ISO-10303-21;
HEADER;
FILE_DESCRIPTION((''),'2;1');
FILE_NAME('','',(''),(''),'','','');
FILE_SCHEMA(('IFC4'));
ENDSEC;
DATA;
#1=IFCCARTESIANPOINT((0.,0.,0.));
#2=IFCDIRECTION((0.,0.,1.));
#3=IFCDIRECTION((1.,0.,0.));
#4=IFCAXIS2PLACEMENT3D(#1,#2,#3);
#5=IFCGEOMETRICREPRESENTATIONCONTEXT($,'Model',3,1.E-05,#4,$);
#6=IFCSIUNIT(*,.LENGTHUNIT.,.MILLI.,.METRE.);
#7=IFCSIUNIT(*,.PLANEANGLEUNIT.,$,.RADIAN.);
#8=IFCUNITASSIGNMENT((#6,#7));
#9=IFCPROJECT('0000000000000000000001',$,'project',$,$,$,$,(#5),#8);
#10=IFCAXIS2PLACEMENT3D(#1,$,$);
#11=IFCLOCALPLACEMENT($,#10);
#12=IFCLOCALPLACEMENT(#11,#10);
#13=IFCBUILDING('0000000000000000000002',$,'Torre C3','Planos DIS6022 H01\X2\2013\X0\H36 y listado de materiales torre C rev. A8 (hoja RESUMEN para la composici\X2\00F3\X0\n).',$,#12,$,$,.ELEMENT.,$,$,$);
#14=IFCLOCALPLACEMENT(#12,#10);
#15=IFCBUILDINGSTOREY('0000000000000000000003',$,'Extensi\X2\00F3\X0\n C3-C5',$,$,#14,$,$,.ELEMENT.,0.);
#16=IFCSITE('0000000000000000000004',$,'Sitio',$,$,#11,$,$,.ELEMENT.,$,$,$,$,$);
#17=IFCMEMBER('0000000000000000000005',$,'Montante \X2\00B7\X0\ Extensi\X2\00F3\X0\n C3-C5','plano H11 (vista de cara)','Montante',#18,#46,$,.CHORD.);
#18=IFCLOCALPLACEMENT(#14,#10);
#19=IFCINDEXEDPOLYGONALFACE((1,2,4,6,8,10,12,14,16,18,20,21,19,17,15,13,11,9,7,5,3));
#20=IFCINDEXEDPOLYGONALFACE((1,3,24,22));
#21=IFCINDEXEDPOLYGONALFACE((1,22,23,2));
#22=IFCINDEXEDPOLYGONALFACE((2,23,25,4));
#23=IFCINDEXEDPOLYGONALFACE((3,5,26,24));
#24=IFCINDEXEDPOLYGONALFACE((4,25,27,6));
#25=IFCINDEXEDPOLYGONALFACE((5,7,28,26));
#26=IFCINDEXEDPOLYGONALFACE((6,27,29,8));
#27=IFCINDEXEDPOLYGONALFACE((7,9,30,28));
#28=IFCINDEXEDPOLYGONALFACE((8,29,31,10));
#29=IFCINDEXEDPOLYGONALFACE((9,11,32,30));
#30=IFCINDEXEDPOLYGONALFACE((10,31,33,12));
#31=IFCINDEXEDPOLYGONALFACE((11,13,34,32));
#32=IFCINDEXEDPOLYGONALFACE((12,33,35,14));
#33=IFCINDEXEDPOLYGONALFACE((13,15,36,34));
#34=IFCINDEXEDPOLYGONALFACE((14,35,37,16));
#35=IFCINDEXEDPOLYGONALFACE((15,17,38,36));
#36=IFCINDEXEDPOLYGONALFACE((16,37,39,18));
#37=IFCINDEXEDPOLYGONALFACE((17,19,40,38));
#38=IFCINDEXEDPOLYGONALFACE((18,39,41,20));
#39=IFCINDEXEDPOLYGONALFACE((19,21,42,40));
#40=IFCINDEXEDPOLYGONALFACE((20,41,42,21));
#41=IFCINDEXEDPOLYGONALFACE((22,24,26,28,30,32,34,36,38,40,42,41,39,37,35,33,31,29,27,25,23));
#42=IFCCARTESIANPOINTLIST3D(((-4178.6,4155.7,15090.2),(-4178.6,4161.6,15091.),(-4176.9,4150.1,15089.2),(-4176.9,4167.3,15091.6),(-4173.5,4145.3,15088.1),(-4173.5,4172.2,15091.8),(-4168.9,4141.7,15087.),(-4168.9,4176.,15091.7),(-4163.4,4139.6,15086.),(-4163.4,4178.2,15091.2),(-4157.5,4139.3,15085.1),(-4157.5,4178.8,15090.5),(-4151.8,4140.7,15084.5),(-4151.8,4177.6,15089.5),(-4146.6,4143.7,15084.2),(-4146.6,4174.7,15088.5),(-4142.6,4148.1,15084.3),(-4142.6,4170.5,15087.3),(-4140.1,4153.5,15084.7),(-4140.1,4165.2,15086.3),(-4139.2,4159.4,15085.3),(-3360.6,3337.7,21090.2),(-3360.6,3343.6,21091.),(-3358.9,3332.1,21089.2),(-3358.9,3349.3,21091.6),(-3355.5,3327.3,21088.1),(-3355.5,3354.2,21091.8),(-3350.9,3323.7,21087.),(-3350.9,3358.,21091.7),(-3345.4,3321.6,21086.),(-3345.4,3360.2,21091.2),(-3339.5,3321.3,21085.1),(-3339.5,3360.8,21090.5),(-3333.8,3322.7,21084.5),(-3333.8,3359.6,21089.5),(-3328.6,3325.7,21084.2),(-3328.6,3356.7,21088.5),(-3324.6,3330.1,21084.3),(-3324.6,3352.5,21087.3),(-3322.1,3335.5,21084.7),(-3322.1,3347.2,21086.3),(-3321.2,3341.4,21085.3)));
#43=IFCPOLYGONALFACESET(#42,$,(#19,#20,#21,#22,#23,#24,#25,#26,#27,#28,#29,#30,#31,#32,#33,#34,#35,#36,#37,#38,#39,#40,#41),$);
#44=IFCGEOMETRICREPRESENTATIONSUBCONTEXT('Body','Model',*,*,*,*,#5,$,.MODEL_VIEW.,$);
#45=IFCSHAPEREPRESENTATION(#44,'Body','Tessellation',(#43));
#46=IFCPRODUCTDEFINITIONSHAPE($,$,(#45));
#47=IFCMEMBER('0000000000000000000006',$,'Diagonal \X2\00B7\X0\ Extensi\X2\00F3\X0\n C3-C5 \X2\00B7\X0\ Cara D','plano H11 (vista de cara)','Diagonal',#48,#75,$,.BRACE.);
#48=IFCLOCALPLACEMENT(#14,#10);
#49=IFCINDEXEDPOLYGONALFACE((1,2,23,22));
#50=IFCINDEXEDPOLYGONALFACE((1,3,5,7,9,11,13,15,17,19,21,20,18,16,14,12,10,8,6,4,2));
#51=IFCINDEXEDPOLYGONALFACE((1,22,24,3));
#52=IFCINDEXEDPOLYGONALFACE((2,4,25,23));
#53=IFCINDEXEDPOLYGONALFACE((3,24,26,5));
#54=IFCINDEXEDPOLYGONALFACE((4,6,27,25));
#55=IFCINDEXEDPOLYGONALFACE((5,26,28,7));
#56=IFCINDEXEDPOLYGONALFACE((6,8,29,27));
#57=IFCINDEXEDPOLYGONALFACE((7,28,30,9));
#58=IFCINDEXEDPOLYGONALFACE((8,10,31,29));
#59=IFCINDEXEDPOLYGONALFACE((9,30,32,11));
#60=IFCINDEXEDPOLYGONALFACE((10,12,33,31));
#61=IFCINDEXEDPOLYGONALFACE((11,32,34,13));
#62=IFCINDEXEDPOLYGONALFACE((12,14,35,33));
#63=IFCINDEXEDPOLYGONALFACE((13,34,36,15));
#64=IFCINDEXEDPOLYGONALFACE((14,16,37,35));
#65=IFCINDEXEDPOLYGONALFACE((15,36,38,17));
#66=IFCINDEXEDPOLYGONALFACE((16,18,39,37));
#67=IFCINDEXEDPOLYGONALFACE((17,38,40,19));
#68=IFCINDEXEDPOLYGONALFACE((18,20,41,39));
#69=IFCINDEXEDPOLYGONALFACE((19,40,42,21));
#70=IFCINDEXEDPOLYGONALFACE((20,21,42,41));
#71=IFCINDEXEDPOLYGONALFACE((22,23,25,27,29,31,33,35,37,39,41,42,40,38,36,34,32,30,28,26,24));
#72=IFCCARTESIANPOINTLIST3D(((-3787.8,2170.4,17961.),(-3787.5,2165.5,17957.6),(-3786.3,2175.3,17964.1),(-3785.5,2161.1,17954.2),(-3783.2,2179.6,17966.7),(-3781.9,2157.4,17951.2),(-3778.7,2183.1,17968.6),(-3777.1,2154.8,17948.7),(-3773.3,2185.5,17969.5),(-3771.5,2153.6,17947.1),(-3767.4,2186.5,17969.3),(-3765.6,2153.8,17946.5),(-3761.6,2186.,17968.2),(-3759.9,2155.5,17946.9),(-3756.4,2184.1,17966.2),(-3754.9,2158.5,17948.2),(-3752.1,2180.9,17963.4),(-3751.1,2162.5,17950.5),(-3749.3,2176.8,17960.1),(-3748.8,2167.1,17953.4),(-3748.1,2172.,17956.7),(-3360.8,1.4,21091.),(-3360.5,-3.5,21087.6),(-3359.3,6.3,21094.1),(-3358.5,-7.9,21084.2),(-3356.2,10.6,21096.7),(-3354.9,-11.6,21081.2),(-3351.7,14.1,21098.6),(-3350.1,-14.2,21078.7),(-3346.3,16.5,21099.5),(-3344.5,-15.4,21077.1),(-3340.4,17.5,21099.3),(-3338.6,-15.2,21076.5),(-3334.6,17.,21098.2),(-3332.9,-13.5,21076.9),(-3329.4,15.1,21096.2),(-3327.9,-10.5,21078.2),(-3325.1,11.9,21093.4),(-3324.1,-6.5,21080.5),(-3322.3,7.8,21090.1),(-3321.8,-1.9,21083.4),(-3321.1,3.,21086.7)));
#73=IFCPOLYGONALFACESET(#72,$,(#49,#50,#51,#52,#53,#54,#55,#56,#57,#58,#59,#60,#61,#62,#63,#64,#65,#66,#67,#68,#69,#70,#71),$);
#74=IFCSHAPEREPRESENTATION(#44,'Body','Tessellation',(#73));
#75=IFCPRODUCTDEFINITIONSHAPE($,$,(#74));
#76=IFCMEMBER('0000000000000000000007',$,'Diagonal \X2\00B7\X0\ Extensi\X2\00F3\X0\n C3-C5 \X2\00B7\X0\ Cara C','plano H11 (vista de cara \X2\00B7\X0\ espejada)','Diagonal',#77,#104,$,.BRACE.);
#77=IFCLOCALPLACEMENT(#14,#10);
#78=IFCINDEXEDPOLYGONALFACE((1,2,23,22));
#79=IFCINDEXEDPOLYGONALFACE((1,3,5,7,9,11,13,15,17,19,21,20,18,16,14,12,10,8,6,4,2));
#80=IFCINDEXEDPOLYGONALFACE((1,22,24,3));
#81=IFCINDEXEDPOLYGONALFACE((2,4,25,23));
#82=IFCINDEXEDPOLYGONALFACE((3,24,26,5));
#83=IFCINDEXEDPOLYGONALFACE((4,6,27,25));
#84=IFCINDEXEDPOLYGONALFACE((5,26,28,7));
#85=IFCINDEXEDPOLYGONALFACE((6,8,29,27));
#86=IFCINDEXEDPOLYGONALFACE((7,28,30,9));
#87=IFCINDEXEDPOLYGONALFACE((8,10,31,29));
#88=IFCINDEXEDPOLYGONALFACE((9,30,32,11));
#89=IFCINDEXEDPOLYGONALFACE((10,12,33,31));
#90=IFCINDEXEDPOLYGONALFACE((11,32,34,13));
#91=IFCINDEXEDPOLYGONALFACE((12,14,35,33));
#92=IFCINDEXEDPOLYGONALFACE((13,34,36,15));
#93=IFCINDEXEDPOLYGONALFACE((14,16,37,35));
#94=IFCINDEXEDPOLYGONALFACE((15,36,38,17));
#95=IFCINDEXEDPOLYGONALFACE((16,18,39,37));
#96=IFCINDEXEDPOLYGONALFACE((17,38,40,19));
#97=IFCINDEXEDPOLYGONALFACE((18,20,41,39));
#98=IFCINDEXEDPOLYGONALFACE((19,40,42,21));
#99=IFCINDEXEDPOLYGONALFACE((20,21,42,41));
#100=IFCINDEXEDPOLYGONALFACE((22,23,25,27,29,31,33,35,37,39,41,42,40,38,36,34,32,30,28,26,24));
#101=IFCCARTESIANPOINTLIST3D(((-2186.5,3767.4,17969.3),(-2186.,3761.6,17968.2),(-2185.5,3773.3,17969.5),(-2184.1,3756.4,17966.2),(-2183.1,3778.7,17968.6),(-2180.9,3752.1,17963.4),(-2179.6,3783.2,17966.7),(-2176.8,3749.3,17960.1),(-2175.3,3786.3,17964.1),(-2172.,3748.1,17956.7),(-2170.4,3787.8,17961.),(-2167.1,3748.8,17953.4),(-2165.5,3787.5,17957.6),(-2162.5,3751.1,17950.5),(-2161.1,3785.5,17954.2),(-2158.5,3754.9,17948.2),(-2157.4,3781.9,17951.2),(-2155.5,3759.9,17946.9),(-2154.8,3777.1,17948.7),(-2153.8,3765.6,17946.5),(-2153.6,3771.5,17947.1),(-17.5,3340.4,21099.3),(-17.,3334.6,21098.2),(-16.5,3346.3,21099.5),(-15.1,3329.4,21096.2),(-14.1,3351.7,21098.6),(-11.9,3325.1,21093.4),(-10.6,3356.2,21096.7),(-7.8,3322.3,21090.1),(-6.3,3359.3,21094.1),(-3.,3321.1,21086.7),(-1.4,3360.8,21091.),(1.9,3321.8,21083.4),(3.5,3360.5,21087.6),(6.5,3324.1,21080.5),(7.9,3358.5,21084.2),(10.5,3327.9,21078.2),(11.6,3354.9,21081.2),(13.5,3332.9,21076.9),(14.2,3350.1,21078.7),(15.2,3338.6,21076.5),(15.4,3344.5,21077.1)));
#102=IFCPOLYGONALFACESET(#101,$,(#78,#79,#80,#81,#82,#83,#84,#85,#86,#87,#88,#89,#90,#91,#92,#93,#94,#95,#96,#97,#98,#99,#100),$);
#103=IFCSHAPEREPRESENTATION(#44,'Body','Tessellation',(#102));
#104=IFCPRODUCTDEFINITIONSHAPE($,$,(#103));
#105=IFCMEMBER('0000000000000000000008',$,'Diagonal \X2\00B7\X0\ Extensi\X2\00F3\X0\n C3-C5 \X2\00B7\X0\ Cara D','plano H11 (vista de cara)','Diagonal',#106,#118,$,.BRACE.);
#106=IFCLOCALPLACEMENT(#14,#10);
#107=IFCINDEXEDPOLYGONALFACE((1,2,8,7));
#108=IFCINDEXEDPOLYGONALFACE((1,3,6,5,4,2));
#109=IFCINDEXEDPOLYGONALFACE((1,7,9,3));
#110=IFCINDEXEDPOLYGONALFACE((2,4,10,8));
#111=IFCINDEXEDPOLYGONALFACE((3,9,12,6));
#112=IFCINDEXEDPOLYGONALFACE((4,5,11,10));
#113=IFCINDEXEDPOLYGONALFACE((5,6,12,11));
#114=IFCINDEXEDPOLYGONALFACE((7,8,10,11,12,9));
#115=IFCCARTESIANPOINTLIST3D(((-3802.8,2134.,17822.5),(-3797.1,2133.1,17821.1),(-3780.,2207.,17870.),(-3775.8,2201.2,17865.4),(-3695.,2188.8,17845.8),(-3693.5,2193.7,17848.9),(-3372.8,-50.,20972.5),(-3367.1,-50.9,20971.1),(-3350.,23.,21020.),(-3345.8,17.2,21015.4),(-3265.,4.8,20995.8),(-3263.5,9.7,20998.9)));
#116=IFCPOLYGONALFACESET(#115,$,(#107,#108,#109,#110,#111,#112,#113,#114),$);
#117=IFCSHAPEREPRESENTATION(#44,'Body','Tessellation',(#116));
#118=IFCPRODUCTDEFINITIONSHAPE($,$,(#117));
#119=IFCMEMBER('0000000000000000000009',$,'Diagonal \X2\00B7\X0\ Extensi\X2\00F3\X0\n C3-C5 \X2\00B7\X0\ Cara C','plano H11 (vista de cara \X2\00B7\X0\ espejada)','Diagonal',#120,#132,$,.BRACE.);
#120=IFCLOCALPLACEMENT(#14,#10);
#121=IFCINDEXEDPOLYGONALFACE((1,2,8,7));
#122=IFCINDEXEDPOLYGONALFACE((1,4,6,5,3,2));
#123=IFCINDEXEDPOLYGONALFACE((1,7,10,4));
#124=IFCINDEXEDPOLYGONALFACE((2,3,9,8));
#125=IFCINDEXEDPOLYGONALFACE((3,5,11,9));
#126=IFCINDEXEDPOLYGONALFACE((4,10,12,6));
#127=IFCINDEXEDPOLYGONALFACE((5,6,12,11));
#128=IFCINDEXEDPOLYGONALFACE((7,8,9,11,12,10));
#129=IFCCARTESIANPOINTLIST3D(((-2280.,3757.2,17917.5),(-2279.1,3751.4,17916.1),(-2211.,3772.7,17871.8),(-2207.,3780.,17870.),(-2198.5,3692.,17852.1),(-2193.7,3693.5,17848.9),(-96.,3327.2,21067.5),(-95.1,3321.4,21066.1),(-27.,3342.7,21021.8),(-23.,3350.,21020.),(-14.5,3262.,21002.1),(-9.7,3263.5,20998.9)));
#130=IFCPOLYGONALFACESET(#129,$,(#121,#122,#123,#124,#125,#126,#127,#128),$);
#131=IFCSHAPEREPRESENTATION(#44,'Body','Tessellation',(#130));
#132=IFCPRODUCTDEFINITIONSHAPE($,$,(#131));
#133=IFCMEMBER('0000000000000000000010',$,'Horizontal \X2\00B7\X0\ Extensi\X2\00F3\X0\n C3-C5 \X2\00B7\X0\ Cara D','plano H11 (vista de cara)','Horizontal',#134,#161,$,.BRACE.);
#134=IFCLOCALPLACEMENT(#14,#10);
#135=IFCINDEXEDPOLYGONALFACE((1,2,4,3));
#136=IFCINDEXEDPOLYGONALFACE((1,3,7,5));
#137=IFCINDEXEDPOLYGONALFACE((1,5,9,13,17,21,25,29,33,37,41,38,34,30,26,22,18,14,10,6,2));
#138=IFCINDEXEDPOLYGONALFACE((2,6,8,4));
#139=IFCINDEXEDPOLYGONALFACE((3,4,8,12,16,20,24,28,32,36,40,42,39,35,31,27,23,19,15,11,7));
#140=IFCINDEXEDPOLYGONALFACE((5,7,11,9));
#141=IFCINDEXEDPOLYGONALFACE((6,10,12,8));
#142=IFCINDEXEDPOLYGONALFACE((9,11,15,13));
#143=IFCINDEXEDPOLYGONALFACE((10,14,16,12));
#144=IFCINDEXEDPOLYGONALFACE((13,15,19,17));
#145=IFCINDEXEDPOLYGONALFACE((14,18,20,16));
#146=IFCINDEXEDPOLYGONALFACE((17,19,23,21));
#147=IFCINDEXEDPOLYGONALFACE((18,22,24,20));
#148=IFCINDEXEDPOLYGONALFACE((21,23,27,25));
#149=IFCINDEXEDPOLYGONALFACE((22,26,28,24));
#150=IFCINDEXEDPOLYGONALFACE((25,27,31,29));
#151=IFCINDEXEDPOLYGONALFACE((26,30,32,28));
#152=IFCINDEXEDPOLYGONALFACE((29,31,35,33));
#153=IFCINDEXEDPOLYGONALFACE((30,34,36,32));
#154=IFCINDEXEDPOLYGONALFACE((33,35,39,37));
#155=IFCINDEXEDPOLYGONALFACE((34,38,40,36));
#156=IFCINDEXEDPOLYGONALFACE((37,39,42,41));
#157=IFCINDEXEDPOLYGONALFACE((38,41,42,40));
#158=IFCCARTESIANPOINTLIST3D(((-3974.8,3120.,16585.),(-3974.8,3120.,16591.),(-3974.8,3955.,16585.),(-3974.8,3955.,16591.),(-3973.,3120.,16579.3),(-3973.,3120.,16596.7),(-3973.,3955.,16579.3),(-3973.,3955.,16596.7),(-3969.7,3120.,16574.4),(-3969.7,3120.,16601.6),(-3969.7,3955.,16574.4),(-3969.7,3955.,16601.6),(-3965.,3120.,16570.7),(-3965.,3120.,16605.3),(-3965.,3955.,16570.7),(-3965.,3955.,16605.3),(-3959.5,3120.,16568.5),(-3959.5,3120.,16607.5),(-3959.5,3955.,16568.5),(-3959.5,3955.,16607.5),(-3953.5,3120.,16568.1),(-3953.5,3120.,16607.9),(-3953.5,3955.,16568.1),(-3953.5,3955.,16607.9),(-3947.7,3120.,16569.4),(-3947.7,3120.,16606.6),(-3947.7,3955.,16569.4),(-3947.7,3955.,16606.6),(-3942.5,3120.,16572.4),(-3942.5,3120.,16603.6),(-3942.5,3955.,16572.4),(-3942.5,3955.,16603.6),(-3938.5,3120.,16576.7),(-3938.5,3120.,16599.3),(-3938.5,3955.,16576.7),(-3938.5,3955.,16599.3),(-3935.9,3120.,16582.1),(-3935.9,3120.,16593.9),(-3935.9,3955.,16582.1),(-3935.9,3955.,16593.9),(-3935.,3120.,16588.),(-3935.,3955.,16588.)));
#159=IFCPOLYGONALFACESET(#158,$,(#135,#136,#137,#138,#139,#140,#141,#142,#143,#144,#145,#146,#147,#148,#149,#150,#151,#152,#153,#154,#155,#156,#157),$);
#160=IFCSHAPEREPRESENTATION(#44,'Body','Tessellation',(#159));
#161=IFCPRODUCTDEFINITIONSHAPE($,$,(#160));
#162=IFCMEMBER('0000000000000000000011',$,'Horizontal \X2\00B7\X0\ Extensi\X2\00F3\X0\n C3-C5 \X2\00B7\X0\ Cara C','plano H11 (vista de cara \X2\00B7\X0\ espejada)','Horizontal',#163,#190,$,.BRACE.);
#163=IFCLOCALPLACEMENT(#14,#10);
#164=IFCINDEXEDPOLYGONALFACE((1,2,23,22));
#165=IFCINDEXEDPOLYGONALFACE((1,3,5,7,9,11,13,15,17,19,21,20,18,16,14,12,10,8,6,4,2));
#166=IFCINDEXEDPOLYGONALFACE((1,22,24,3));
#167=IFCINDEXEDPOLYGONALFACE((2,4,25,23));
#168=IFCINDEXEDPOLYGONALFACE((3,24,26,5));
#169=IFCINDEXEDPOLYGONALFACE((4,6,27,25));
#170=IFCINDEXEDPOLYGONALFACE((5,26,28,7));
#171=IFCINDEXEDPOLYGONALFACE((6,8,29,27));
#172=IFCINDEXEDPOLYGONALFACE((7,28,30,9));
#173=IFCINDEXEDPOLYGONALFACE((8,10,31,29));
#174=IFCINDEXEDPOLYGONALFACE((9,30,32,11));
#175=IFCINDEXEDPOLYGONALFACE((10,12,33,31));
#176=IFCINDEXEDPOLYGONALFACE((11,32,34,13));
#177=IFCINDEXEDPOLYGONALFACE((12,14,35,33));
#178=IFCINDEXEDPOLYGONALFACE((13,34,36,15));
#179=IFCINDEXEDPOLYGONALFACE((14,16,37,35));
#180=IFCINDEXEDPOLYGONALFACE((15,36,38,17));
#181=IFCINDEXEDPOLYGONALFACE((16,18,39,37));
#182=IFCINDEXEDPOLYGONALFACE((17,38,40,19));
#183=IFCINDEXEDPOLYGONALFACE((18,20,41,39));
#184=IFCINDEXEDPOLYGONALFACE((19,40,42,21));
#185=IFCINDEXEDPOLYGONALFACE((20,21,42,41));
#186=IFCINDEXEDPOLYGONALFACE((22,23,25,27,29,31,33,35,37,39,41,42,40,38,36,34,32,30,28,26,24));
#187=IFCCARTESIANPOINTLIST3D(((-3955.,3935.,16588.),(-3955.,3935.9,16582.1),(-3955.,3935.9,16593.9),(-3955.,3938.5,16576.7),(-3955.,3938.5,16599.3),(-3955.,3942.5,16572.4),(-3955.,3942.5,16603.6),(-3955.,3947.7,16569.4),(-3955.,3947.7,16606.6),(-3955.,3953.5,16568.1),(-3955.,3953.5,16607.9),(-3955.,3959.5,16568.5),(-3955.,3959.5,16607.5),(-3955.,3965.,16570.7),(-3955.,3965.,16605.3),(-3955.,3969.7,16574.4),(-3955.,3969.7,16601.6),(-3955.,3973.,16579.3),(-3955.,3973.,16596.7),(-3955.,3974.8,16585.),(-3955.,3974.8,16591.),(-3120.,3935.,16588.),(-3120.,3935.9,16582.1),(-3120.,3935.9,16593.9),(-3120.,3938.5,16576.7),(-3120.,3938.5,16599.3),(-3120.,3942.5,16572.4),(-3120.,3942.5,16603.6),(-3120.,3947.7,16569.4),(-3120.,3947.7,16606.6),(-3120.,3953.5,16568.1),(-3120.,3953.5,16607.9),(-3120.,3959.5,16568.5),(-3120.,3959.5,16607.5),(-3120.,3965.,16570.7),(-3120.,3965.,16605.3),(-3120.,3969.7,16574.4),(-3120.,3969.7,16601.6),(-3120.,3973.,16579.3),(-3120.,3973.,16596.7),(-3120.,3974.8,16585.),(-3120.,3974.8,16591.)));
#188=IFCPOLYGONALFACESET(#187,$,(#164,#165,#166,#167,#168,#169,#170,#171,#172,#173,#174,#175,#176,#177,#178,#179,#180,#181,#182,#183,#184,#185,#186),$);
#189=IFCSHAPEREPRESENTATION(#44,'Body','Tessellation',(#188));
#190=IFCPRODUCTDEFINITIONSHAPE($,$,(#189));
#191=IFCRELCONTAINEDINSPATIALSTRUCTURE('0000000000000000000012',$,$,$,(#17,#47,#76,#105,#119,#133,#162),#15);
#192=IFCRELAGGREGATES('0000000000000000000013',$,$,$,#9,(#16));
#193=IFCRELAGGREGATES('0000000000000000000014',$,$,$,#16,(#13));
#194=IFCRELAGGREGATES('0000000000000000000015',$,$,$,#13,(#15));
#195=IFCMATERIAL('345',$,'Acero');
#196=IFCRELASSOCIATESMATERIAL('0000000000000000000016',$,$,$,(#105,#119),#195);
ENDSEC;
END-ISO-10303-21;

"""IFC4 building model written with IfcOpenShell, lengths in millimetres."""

from ifc_helpers import new_model, si_unit, frame, frame_2d, origin, origin_with_axes, place, context, subcontext, project, spatial, circle, l_section, extrude, material, element, save


model = new_model("IFC4")

# Units and contexts
model_context = context("Model", 3, precision=1e-05, world=origin_with_axes())
body_context = subcontext(model_context, "Body", "Model", "MODEL_VIEW")
ifc_project = project(units=[si_unit("LENGTHUNIT", "METRE", prefix="MILLI"), si_unit("PLANEANGLEUNIT", "RADIAN")], contexts=[model_context])

# Site, building, storey
site_placement = place(None, origin())
site = spatial("IfcSite", under=ifc_project, at=site_placement, Name="Sitio", CompositionType="ELEMENT")
building_placement = place(site_placement, origin())
building = spatial("IfcBuilding", under=site, at=building_placement, Name="Torre C3", Description="Planos DIS6022 H01–H36 y listado de materiales torre C rev. A8 (hoja RESUMEN para la composición).", CompositionType="ELEMENT")
storey_placement = place(building_placement, origin())
storey = spatial("IfcBuildingStorey", under=building, at=storey_placement, Name="Extensión C3-C5", CompositionType="ELEMENT", Elevation=0.0)

# Members
member_placement = place(storey_placement, frame((-3341.0, 3341.0, 21088.0), z_axis=(-0.133868, 0.133868, -0.981916), x_axis=(0.990999, 0.018083, -0.132641)))
element("IfcMember", 1, at=member_placement, inside=storey, Name="Montante · Extensión C3-C5", Description="plano H11 (vista de cara)", ObjectType="Montante", PredefinedType="CHORD", context=body_context, shape_type="SweptSolid", body=[
    extrude(circle(Radius=20.0), None, (0.0, 0.0, 1.0), 6110.5),
])
for number, where, z_axis, x_axis, name, description in (
    (2, (-3341.0, 1.0, 21088.0), (-0.111432, 0.566031, -0.816818), (0.962353, -0.14358, -0.230783), "Diagonal · Extensión C3-C5 · Cara D", "plano H11 (vista de cara)"),
    (3, (-1.0, 3341.0, 21088.0), (-0.566031, 0.111432, -0.816818), (0.14358, -0.962353, -0.230783), "Diagonal · Extensión C3-C5 · Cara C", "plano H11 (vista de cara · espejada)"),
):
    element("IfcMember", number, at=place(storey_placement, frame(where, z_axis=z_axis, x_axis=x_axis)), inside=storey, Name=name, Description=description, ObjectType="Diagonal", PredefinedType="BRACE", context=body_context, shape_type="SweptSolid", body=[
        extrude(circle(Radius=20.0), None, (0.0, 0.0, 1.0), 3831.9),
    ])
ifc_material_1 = material(Name="345", Category="Acero")
for number, where, z_axis, x_axis, name, description in (
    (4, (-3350.0, 23.0, 21020.0), (-0.111483, 0.566228, -0.816675), (0.960867, -0.148288, -0.233979), "Diagonal · Extensión C3-C5 · Cara D", "plano H11 (vista de cara)"),
    (5, (-23.0, 3350.0, 21020.0), (-0.566228, 0.111483, -0.816675), (0.148288, -0.960867, -0.233979), "Diagonal · Extensión C3-C5 · Cara C", "plano H11 (vista de cara · espejada)"),
):
    element("IfcMember", number, at=place(storey_placement, frame(where, z_axis=z_axis, x_axis=x_axis)), inside=storey, material=ifc_material_1, Name=name, Description=description, ObjectType="Diagonal", PredefinedType="BRACE", context=body_context, shape_type="SweptSolid", body=[
        extrude(l_section(Depth=90.0, Width=90.0, Thickness=6.0, at=frame_2d((45.0, 45.0))), None, (0.0, 0.0, 1.0), 3857.1),
    ])
for number, where, z_axis, x_axis, name, description in (
    (6, (-3955.0, 3120.0, 16588.0), (0.0, 1.0, 0.0), (1.0, 0.0, 0.0), "Horizontal · Extensión C3-C5 · Cara D", "plano H11 (vista de cara)"),
    (7, (-3120.0, 3955.0, 16588.0), (-1.0, 0.0, 0.0), (0.0, -1.0, 0.0), "Horizontal · Extensión C3-C5 · Cara C", "plano H11 (vista de cara · espejada)"),
):
    element("IfcMember", number, at=place(storey_placement, frame(where, z_axis=z_axis, x_axis=x_axis)), inside=storey, Name=name, Description=description, ObjectType="Horizontal", PredefinedType="BRACE", context=body_context, shape_type="SweptSolid", body=[
        extrude(circle(Radius=20.0), None, (0.0, 0.0, 1.0), 835.0),
    ])

save(model, "model.ifc")
